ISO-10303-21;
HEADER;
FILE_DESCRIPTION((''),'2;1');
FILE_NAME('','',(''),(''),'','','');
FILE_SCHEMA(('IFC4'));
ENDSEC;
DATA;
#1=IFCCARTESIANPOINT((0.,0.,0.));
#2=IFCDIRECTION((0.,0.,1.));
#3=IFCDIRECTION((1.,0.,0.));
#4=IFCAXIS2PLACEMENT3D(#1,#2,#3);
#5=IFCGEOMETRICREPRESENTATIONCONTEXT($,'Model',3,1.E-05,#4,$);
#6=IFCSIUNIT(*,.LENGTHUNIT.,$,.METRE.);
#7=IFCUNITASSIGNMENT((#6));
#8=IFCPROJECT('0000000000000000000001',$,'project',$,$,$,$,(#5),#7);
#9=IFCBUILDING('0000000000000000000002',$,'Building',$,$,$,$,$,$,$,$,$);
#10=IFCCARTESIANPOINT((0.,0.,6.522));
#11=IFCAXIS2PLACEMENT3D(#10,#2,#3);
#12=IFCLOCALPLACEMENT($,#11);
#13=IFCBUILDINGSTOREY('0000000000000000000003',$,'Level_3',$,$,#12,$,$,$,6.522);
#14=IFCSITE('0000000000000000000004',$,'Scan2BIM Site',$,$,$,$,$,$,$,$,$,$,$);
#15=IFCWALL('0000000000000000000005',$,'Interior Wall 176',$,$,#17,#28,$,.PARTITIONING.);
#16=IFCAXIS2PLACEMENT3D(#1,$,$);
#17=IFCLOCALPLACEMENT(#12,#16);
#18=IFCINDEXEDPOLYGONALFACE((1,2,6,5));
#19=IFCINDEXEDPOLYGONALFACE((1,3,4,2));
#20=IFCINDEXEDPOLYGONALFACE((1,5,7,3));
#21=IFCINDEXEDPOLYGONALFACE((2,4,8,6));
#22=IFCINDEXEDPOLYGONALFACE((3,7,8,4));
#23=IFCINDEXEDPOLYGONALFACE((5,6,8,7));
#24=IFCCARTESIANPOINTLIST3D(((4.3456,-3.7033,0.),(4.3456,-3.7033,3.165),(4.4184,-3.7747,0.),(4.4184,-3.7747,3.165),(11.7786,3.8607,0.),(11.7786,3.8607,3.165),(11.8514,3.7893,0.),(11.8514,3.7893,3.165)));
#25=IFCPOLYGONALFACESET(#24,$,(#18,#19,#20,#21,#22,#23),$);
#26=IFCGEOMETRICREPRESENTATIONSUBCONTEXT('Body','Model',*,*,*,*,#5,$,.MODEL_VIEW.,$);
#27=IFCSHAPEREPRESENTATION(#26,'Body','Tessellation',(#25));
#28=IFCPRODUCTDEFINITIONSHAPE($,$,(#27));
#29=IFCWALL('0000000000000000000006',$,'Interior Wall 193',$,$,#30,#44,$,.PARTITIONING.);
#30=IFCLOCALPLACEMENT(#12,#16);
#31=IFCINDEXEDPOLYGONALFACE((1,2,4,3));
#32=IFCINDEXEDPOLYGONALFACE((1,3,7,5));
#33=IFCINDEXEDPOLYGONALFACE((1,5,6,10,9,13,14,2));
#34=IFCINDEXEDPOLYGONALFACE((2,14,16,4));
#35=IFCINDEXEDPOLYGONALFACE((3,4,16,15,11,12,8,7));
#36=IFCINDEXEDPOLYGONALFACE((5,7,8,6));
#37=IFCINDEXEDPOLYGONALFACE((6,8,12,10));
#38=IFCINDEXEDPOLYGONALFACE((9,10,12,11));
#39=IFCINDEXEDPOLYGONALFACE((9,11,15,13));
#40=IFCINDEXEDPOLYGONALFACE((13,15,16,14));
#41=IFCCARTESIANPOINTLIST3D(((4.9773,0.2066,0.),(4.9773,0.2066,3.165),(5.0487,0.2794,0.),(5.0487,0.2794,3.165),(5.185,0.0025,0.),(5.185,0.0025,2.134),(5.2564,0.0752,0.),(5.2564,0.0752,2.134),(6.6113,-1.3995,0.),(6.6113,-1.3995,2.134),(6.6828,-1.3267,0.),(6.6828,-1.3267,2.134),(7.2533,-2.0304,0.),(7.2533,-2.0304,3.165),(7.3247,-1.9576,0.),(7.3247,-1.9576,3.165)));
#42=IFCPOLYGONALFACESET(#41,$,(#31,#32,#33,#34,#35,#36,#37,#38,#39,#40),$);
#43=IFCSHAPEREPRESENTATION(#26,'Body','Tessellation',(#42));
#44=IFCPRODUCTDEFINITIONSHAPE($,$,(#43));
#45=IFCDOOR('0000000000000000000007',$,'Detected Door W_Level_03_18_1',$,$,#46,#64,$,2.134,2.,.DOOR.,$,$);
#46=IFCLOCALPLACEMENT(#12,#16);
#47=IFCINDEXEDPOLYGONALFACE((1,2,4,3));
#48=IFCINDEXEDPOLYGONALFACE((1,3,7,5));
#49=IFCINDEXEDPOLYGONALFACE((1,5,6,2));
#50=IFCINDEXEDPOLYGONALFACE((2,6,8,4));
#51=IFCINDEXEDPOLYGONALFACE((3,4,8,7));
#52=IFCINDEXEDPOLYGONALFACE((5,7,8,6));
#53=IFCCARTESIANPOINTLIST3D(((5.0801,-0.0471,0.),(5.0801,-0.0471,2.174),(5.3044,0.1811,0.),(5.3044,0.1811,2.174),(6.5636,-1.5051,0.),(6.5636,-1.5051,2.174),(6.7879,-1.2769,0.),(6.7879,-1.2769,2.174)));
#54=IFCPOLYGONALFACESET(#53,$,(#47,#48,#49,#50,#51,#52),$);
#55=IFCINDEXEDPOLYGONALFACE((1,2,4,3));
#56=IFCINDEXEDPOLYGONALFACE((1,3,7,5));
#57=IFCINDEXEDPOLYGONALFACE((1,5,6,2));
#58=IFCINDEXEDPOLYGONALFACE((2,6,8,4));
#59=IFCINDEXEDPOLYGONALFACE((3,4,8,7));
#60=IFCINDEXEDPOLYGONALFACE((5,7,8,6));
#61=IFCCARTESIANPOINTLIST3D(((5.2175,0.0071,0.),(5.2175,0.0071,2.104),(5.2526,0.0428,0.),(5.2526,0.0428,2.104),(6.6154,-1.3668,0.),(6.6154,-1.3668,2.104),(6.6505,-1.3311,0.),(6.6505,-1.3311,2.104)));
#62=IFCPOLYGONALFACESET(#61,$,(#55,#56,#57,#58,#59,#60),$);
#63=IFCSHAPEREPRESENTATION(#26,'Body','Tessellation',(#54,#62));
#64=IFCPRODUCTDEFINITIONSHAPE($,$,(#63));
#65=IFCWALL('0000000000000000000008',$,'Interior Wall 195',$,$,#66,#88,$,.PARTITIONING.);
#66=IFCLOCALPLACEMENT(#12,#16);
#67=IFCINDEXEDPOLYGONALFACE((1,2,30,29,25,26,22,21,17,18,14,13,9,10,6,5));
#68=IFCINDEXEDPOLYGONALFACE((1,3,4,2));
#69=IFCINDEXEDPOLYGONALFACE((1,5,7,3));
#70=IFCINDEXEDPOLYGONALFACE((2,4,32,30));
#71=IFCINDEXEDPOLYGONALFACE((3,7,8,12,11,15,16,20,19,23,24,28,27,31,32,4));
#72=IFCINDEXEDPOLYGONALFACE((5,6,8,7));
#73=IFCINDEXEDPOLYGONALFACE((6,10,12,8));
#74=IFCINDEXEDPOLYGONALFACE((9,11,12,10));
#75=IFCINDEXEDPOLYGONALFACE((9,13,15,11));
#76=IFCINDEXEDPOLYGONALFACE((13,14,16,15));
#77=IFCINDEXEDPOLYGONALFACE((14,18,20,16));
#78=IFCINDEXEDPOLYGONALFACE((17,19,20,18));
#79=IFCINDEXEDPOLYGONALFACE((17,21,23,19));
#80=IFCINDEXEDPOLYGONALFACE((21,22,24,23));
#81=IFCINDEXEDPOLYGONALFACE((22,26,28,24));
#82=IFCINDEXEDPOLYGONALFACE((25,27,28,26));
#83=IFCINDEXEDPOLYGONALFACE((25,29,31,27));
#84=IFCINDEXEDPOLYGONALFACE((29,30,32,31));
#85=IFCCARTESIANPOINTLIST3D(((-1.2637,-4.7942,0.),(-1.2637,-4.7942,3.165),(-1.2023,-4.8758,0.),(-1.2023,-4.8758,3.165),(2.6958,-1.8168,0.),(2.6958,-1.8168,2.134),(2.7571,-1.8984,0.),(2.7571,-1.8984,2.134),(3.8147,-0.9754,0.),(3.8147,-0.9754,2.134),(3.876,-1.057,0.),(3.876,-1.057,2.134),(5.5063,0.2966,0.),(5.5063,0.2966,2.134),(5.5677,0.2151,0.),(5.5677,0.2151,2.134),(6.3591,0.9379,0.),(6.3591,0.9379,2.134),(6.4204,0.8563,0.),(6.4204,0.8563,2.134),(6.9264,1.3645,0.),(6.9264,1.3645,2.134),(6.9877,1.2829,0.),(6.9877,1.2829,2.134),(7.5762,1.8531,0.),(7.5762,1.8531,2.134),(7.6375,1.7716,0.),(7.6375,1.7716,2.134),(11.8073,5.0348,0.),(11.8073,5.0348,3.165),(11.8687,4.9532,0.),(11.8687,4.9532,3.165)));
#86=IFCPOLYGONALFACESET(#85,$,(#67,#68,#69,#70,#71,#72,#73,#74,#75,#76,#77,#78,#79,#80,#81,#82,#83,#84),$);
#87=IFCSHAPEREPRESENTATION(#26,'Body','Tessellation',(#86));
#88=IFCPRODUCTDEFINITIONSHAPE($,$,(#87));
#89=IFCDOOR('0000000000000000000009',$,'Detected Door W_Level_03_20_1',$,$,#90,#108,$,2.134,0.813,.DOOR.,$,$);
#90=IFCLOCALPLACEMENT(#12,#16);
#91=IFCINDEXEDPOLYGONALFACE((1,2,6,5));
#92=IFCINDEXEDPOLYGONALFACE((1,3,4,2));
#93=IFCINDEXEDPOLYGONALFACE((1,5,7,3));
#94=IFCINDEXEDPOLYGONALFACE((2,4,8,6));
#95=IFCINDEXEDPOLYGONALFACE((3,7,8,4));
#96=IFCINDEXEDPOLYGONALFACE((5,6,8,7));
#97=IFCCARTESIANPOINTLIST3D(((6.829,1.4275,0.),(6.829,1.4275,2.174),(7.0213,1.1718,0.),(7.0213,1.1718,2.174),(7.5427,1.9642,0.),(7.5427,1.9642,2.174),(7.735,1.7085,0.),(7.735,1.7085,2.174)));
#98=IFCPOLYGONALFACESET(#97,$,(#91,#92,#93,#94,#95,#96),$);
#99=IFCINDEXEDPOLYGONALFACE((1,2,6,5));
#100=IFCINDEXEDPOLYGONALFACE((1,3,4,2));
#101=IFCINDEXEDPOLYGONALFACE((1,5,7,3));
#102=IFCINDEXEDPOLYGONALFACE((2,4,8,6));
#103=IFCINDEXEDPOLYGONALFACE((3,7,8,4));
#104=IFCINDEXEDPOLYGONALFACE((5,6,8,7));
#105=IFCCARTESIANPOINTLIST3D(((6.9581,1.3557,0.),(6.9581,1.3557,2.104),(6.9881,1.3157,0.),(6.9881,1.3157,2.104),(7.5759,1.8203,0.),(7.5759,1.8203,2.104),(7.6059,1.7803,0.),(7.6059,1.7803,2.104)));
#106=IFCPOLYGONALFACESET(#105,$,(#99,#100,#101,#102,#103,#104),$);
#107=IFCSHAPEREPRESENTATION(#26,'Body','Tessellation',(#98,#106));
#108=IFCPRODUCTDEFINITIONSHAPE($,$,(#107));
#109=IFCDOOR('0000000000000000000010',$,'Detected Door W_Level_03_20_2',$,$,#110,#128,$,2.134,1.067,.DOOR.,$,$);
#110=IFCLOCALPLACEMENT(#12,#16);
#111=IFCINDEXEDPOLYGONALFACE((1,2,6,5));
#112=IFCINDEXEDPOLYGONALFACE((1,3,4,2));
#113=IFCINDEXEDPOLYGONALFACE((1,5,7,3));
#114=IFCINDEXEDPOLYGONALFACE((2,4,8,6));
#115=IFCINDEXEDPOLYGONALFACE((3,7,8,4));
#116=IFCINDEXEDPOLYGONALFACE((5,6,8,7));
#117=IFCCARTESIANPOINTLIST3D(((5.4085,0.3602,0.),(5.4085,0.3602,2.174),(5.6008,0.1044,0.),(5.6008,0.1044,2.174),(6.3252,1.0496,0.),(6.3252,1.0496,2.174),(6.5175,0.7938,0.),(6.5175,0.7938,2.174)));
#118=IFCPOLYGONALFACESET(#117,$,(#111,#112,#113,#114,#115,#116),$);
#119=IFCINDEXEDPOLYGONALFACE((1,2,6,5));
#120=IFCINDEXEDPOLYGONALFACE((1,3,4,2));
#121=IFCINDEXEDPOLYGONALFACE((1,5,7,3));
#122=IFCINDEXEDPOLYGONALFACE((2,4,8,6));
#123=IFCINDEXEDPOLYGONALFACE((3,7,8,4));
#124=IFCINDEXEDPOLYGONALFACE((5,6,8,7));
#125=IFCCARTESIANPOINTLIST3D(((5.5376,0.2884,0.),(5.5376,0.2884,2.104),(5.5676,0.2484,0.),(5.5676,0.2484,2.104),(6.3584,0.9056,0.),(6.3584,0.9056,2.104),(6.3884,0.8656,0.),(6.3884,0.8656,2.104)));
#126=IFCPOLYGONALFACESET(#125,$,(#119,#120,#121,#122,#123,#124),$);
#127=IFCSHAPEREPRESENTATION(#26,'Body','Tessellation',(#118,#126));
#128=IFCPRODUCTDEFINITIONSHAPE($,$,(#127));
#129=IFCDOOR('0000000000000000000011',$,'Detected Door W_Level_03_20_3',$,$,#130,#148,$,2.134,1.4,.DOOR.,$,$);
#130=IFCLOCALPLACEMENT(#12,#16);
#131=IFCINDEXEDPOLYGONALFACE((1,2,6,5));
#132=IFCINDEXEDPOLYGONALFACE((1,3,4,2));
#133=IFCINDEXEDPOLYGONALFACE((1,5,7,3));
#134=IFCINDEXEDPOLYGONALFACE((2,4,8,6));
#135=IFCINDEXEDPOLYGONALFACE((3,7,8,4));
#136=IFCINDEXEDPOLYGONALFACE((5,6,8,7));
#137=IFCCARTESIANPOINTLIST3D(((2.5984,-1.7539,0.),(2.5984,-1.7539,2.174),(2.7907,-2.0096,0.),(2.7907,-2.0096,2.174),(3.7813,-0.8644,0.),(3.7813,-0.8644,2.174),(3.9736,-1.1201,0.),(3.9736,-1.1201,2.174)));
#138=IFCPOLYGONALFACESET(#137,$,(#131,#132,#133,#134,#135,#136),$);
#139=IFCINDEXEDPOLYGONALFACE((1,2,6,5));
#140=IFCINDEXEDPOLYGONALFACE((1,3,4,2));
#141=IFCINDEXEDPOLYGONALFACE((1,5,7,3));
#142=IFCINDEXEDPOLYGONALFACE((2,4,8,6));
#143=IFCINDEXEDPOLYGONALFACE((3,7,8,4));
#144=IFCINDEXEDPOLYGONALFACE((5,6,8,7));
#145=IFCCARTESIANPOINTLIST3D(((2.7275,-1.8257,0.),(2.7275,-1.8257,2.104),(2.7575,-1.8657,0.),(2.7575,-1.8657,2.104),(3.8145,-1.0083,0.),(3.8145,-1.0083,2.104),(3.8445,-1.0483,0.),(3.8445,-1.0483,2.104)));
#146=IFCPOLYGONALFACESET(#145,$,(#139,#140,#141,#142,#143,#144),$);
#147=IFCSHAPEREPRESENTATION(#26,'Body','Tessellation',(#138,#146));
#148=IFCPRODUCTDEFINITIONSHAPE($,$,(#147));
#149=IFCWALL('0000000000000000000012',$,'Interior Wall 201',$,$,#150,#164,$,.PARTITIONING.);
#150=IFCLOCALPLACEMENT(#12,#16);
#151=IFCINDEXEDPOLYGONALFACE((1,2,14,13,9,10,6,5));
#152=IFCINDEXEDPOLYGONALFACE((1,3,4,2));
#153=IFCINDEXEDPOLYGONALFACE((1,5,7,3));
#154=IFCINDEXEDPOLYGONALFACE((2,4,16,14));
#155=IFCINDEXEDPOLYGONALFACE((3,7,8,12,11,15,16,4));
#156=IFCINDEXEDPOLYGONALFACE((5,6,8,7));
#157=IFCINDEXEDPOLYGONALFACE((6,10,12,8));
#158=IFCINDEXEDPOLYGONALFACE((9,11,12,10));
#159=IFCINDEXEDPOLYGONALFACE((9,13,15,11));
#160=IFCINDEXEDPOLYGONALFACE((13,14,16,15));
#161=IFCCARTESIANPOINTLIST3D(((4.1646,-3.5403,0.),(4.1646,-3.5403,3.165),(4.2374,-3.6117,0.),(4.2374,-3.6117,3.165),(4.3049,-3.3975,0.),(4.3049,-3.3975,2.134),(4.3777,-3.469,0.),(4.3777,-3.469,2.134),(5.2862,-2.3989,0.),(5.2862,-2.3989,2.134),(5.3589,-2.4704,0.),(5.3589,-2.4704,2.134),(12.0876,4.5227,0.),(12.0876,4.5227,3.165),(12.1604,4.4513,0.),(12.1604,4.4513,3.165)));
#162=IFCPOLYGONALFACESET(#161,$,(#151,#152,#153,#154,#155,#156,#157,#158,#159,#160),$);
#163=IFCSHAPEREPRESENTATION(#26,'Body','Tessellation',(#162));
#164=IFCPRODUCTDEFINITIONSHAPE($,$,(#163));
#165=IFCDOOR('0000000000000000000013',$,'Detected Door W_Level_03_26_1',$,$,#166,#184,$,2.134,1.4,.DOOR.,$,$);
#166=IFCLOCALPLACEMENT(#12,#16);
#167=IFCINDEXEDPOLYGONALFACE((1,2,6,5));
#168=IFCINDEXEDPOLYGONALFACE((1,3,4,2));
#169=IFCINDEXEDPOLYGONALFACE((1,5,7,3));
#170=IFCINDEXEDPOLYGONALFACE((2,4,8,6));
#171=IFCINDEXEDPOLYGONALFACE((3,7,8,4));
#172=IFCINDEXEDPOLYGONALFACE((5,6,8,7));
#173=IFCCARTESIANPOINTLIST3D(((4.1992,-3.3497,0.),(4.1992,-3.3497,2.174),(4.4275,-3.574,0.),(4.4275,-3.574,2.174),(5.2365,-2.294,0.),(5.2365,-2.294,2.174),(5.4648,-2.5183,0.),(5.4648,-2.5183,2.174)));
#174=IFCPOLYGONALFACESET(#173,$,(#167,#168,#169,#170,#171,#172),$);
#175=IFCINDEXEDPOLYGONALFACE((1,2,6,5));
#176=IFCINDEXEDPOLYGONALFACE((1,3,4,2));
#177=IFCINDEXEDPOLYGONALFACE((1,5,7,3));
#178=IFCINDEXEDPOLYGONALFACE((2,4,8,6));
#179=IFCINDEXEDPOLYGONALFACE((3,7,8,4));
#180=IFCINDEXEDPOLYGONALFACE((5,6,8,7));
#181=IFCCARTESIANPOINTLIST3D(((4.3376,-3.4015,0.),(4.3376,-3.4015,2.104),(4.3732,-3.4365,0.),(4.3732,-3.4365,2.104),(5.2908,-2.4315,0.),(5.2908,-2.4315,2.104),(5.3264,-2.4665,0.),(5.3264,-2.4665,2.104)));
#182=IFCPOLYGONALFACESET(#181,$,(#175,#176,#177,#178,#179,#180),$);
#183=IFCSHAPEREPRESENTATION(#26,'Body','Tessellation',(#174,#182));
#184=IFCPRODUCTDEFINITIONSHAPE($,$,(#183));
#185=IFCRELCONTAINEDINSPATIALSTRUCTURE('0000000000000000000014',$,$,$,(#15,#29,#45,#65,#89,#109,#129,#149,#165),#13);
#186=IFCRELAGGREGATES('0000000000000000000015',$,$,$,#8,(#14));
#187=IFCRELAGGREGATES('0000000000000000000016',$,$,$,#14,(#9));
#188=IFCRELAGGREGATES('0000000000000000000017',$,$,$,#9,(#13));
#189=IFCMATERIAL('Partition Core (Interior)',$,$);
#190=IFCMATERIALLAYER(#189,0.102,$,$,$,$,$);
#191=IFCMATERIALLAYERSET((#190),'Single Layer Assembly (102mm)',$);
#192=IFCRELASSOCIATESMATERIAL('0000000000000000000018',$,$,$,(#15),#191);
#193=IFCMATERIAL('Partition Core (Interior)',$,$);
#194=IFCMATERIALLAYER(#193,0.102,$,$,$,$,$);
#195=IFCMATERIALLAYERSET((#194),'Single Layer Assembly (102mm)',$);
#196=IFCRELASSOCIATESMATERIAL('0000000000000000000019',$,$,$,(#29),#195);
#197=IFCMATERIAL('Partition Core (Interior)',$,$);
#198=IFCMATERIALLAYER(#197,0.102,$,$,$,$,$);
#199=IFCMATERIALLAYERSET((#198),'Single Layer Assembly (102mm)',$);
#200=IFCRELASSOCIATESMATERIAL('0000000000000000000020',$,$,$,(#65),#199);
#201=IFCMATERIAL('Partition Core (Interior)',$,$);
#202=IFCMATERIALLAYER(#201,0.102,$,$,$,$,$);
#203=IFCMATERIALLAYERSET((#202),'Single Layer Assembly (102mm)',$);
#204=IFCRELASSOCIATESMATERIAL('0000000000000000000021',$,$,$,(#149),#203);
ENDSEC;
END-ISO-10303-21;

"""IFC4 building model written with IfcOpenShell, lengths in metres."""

from ifc_helpers import new_model, si_unit, frame, origin, origin_with_axes, place, context, subcontext, project, spatial, rectangle, extrude, material, layer, layer_set, element, fill, save


model = new_model("IFC4")

# Units and contexts
model_context = context("Model", 3, precision=1e-05, world=origin_with_axes())
body_context = subcontext(model_context, "Body", "Model", "MODEL_VIEW")
ifc_project = project(units=[si_unit("LENGTHUNIT", "METRE")], contexts=[model_context])

# Site, building, storey
site = spatial("IfcSite", under=ifc_project, Name="Scan2BIM Site")
building = spatial("IfcBuilding", under=site, Name="Building")
storey_placement = place(None, frame((0.0, 0.0, 6.522), z_axis=(0.0, 0.0, 1.0), x_axis=(1.0, 0.0, 0.0)))
storey = spatial("IfcBuildingStorey", under=building, at=storey_placement, Name="Level_3", Elevation=6.522)

# Wall
ifc_material_1 = material(Name="Partition Core (Interior)")
ifc_layer_1 = layer(ifc_material_1, 0.102)
ifc_layer_set_1 = layer_set([ifc_layer_1], Name="Single Layer Assembly (102mm)")
wall_1_placement = place(storey_placement, frame((8.0985, 0.043, 0.0), z_axis=(0.0, 0.0, 1.0), x_axis=(-0.700903, -0.713256, 0.0)))
element("IfcWall", 1, at=wall_1_placement, inside=storey, material=ifc_layer_set_1, Name="Interior Wall 176", PredefinedType="PARTITIONING", context=body_context, shape_type="SweptSolid", body=[
    extrude(rectangle(XDim=10.6049, YDim=0.102), origin(), (0.0, 0.0, 1.0), 3.165),
])

# Wall, opening, door
ifc_material_2 = material(Name="Partition Core (Interior)")
ifc_layer_2 = layer(ifc_material_2, 0.102)
ifc_layer_set_2 = layer_set([ifc_layer_2], Name="Single Layer Assembly (102mm)")
wall_2_placement = place(storey_placement, frame((6.151, -0.8755, 0.0), z_axis=(0.0, 0.0, 1.0), x_axis=(-0.713191, 0.70097, 0.0)))
wall_2 = element("IfcWall", 2, at=wall_2_placement, inside=storey, material=ifc_layer_set_2, Name="Interior Wall 193", PredefinedType="PARTITIONING", context=body_context, shape_type="SweptSolid", body=[
    extrude(rectangle(XDim=3.1913, YDim=0.102), origin(), (0.0, 0.0, 1.0), 3.165),
])
opening_1_placement = place(None, frame((5.934, -0.662, 6.522), z_axis=(0.0, 0.0, 1.0), x_axis=(-0.713191, 0.70097, 0.0)))
opening_1 = element("IfcOpeningElement", 3, at=opening_1_placement, cuts=wall_2, PredefinedType="OPENING", context=body_context, shape_type="SweptSolid", body=[
    extrude(rectangle(XDim=2.0, YDim=0.202), origin(), (0.0, 0.0, 1.0), 2.134),
])
door_1_placement = place(opening_1_placement, frame((0.0, 0.0, 0.0), z_axis=(0.0, 0.0, 1.0), x_axis=(1.0, 0.0, 0.0)))
door_1 = element("IfcDoor", 4, at=door_1_placement, inside=storey, Name="Detected Door W_Level_03_18_1", OverallHeight=2.134, OverallWidth=2.0, PredefinedType="DOOR", context=body_context, shape_type="SweptSolid", body=[
    extrude(rectangle(XDim=2.08, YDim=0.32), origin(), (0.0, 0.0, 1.0), 2.174),
    extrude(rectangle(XDim=1.96, YDim=0.05), origin(), (0.0, 0.0, 1.0), 2.104),
])
fill(opening_1, door_1)

# Wall, openings, doors
ifc_material_3 = material(Name="Partition Core (Interior)")
ifc_layer_3 = layer(ifc_material_3, 0.102)
ifc_layer_set_3 = layer_set([ifc_layer_3], Name="Single Layer Assembly (102mm)")
wall_3_placement = place(storey_placement, frame((5.3025, 0.0795, 0.0), z_axis=(0.0, 0.0, 1.0), x_axis=(-0.799244, -0.601007, 0.0)))
wall_3 = element("IfcWall", 5, at=wall_3_placement, inside=storey, material=ifc_layer_set_3, Name="Interior Wall 195", PredefinedType="PARTITIONING", context=body_context, shape_type="SweptSolid", body=[
    extrude(rectangle(XDim=16.3542, YDim=0.102), origin(), (0.0, 0.0, 1.0), 3.165),
])
opening_2_placement = place(None, frame((7.282, 1.568, 6.522), z_axis=(0.0, 0.0, 1.0), x_axis=(-0.799244, -0.601007, 0.0)))
opening_2 = element("IfcOpeningElement", 6, at=opening_2_placement, cuts=wall_3, PredefinedType="OPENING", context=body_context, shape_type="SweptSolid", body=[
    extrude(rectangle(XDim=0.813, YDim=0.202), origin(), (0.0, 0.0, 1.0), 2.134),
])
opening_3_placement = place(None, frame((5.963, 0.577, 6.522), z_axis=(0.0, 0.0, 1.0), x_axis=(-0.799244, -0.601007, 0.0)))
opening_3 = element("IfcOpeningElement", 7, at=opening_3_placement, cuts=wall_3, PredefinedType="OPENING", context=body_context, shape_type="SweptSolid", body=[
    extrude(rectangle(XDim=1.067, YDim=0.202), origin(), (0.0, 0.0, 1.0), 2.134),
])
opening_4_placement = place(None, frame((3.286, -1.437, 6.522), z_axis=(0.0, 0.0, 1.0), x_axis=(-0.799244, -0.601007, 0.0)))
opening_4 = element("IfcOpeningElement", 8, at=opening_4_placement, cuts=wall_3, PredefinedType="OPENING", context=body_context, shape_type="SweptSolid", body=[
    extrude(rectangle(XDim=1.4, YDim=0.202), origin(), (0.0, 0.0, 1.0), 2.134),
])
door_2_placement = place(opening_2_placement, frame((0.0, 0.0, 0.0), z_axis=(0.0, 0.0, 1.0), x_axis=(1.0, 0.0, 0.0)))
door_2 = element("IfcDoor", 9, at=door_2_placement, inside=storey, Name="Detected Door W_Level_03_20_1", OverallHeight=2.134, OverallWidth=0.813, PredefinedType="DOOR", context=body_context, shape_type="SweptSolid", body=[
    extrude(rectangle(XDim=0.893, YDim=0.32), origin(), (0.0, 0.0, 1.0), 2.174),
    extrude(rectangle(XDim=0.773, YDim=0.05), origin(), (0.0, 0.0, 1.0), 2.104),
])
fill(opening_2, door_2)
door_3_placement = place(opening_3_placement, frame((0.0, 0.0, 0.0), z_axis=(0.0, 0.0, 1.0), x_axis=(1.0, 0.0, 0.0)))
door_3 = element("IfcDoor", 10, at=door_3_placement, inside=storey, Name="Detected Door W_Level_03_20_2", OverallHeight=2.134, OverallWidth=1.067, PredefinedType="DOOR", context=body_context, shape_type="SweptSolid", body=[
    extrude(rectangle(XDim=1.147, YDim=0.32), origin(), (0.0, 0.0, 1.0), 2.174),
    extrude(rectangle(XDim=1.027, YDim=0.05), origin(), (0.0, 0.0, 1.0), 2.104),
])
fill(opening_3, door_3)
door_4_placement = place(opening_4_placement, frame((0.0, 0.0, 0.0), z_axis=(0.0, 0.0, 1.0), x_axis=(1.0, 0.0, 0.0)))
door_4 = element("IfcDoor", 11, at=door_4_placement, inside=storey, Name="Detected Door W_Level_03_20_3", OverallHeight=2.134, OverallWidth=1.4, PredefinedType="DOOR", context=body_context, shape_type="SweptSolid", body=[
    extrude(rectangle(XDim=1.48, YDim=0.32), origin(), (0.0, 0.0, 1.0), 2.174),
    extrude(rectangle(XDim=1.36, YDim=0.05), origin(), (0.0, 0.0, 1.0), 2.104),
])
fill(opening_4, door_4)

# Wall, opening, door
ifc_material_4 = material(Name="Partition Core (Interior)")
ifc_layer_4 = layer(ifc_material_4, 0.102)
ifc_layer_set_4 = layer_set([ifc_layer_4], Name="Single Layer Assembly (102mm)")
wall_4_placement = place(storey_placement, frame((8.1625, 0.4555, 0.0), z_axis=(0.0, 0.0, 1.0), x_axis=(0.700887, 0.713272, 0.0)))
wall_4 = element("IfcWall", 12, at=wall_4_placement, inside=storey, material=ifc_layer_set_4, Name="Interior Wall 201", PredefinedType="PARTITIONING", context=body_context, shape_type="SweptSolid", body=[
    extrude(rectangle(XDim=11.3042, YDim=0.102), origin(), (0.0, 0.0, 1.0), 3.165),
])
opening_5_placement = place(None, frame((4.832, -2.934, 6.522), z_axis=(0.0, 0.0, 1.0), x_axis=(0.700887, 0.713272, 0.0)))
opening_5 = element("IfcOpeningElement", 13, at=opening_5_placement, cuts=wall_4, PredefinedType="OPENING", context=body_context, shape_type="SweptSolid", body=[
    extrude(rectangle(XDim=1.4, YDim=0.202), origin(), (0.0, 0.0, 1.0), 2.134),
])
door_5_placement = place(opening_5_placement, frame((0.0, 0.0, 0.0), z_axis=(0.0, 0.0, 1.0), x_axis=(1.0, 0.0, 0.0)))
door_5 = element("IfcDoor", 14, at=door_5_placement, inside=storey, Name="Detected Door W_Level_03_26_1", OverallHeight=2.134, OverallWidth=1.4, PredefinedType="DOOR", context=body_context, shape_type="SweptSolid", body=[
    extrude(rectangle(XDim=1.48, YDim=0.32), origin(), (0.0, 0.0, 1.0), 2.174),
    extrude(rectangle(XDim=1.36, YDim=0.05), origin(), (0.0, 0.0, 1.0), 2.104),
])
fill(opening_5, door_5)

save(model, "model.ifc")
